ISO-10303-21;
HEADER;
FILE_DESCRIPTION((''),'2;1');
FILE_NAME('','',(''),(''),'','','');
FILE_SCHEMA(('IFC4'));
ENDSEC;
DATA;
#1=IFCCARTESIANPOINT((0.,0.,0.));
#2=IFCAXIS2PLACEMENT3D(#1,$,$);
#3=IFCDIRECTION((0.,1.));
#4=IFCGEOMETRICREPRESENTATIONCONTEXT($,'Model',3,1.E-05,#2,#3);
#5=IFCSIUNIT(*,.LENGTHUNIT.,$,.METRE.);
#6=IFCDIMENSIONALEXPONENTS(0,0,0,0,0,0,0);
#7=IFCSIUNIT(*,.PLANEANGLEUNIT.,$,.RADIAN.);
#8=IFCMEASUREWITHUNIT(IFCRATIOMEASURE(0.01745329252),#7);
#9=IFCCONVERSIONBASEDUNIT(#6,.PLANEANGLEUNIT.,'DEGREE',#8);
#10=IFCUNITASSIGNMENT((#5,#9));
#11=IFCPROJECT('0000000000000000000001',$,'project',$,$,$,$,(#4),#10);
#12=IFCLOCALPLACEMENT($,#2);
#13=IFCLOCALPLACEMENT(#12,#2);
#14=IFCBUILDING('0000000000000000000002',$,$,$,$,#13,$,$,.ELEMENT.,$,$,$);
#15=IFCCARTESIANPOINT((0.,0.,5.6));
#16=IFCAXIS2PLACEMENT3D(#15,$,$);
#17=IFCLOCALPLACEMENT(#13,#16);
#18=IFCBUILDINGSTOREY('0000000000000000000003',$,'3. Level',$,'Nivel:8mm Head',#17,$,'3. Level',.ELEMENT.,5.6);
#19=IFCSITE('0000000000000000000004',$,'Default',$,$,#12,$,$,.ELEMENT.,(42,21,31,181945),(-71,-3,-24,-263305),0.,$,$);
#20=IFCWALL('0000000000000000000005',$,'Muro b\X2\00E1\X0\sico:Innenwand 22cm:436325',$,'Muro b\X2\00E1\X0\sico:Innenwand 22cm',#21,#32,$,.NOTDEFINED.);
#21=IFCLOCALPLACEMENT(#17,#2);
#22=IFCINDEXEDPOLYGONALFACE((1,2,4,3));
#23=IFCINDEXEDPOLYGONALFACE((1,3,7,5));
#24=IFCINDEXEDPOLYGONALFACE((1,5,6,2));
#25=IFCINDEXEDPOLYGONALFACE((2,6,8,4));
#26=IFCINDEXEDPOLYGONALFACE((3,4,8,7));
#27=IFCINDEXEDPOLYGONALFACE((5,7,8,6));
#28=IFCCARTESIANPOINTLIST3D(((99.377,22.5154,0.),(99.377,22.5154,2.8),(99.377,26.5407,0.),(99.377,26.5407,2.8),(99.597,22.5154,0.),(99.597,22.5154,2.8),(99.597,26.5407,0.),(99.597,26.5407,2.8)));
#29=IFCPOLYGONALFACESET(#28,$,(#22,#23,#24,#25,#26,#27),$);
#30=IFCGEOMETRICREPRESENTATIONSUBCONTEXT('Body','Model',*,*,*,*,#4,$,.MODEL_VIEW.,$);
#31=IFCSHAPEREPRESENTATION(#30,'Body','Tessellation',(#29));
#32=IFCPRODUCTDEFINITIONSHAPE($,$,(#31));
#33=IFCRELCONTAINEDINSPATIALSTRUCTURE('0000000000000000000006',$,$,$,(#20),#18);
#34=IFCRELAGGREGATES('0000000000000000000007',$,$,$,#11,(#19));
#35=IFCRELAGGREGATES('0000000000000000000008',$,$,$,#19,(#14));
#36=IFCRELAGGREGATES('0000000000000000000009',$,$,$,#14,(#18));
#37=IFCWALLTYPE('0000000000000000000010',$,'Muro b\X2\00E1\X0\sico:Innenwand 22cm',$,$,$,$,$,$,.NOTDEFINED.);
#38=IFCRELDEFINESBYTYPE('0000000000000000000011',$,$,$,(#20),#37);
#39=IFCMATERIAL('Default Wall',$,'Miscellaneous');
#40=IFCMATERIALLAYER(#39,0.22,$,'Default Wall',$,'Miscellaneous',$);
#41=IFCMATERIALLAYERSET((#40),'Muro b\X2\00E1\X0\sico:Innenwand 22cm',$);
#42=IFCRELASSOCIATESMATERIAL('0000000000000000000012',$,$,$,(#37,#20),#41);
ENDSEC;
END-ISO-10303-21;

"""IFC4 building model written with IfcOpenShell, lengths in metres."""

from ifc_helpers import new_model, entity, si_unit, converted_unit, direction, frame, frame_2d, origin, place, context, subcontext, project, spatial, rectangle, extrude, material, layer, layer_set, layer_usage, type_object, element, save


model = new_model("IFC4")

# Units and contexts
model_context = context("Model", 3, precision=1e-05, world=origin(), true_north=direction((0.0, 1.0)))
body_context = subcontext(model_context, "Body", "Model", "MODEL_VIEW")
ifc_project = project(units=[si_unit("LENGTHUNIT", "METRE"), converted_unit("PLANEANGLEUNIT", "DEGREE", entity("IfcRatioMeasure", 0.01745329252), si_unit("PLANEANGLEUNIT", "RADIAN"), dimensions=[0, 0, 0, 0, 0, 0, 0])], contexts=[model_context])

# Site, building, storey
site_placement = place(None, origin())
site = spatial("IfcSite", under=ifc_project, at=site_placement, Name="Default", CompositionType="ELEMENT", RefLatitude=(42, 21, 31, 181945), RefLongitude=(-71, -3, -24, -263305), RefElevation=0.0)
building_placement = place(site_placement, origin())
building = spatial("IfcBuilding", under=site, at=building_placement, CompositionType="ELEMENT")
storey_placement = place(building_placement, frame((0.0, 0.0, 5.6)))
storey = spatial("IfcBuildingStorey", under=building, at=storey_placement, Name="3. Level", ObjectType="Nivel:8mm Head", LongName="3. Level", CompositionType="ELEMENT", Elevation=5.6)

# Wall
ifc_material_1 = material(Name="Default Wall", Category="Miscellaneous")
ifc_layer_1 = layer(ifc_material_1, 0.22, Name="Default Wall", Category="Miscellaneous")
ifc_layer_set_1 = layer_set([ifc_layer_1], Name="Muro básico:Innenwand 22cm")
ifc_layer_usage_1 = layer_usage(ifc_layer_set_1, "AXIS2", "NEGATIVE", 0.11)
wall_type_1 = type_object("IfcWallType", Name="Muro básico:Innenwand 22cm", PredefinedType="NOTDEFINED", material=ifc_layer_set_1)
wall_1_placement = place(storey_placement, frame((99.487, 22.5154, 0.0), z_axis=(0.0, 0.0, 1.0), x_axis=(0.0, 1.0, 0.0)))
element("IfcWall", 1, at=wall_1_placement, inside=storey, type_object=wall_type_1, material=ifc_layer_usage_1, Name="Muro básico:Innenwand 22cm:436325", ObjectType="Muro básico:Innenwand 22cm", PredefinedType="NOTDEFINED", context=body_context, shape_type="SweptSolid", body=[
    extrude(rectangle(XDim=4.0253, YDim=0.22, at=frame_2d((2.0127, 0.0), x_axis=(-1.0, 0.0))), origin(), (0.0, 0.0, 1.0), 2.8),
])

save(model, "model.ifc")
